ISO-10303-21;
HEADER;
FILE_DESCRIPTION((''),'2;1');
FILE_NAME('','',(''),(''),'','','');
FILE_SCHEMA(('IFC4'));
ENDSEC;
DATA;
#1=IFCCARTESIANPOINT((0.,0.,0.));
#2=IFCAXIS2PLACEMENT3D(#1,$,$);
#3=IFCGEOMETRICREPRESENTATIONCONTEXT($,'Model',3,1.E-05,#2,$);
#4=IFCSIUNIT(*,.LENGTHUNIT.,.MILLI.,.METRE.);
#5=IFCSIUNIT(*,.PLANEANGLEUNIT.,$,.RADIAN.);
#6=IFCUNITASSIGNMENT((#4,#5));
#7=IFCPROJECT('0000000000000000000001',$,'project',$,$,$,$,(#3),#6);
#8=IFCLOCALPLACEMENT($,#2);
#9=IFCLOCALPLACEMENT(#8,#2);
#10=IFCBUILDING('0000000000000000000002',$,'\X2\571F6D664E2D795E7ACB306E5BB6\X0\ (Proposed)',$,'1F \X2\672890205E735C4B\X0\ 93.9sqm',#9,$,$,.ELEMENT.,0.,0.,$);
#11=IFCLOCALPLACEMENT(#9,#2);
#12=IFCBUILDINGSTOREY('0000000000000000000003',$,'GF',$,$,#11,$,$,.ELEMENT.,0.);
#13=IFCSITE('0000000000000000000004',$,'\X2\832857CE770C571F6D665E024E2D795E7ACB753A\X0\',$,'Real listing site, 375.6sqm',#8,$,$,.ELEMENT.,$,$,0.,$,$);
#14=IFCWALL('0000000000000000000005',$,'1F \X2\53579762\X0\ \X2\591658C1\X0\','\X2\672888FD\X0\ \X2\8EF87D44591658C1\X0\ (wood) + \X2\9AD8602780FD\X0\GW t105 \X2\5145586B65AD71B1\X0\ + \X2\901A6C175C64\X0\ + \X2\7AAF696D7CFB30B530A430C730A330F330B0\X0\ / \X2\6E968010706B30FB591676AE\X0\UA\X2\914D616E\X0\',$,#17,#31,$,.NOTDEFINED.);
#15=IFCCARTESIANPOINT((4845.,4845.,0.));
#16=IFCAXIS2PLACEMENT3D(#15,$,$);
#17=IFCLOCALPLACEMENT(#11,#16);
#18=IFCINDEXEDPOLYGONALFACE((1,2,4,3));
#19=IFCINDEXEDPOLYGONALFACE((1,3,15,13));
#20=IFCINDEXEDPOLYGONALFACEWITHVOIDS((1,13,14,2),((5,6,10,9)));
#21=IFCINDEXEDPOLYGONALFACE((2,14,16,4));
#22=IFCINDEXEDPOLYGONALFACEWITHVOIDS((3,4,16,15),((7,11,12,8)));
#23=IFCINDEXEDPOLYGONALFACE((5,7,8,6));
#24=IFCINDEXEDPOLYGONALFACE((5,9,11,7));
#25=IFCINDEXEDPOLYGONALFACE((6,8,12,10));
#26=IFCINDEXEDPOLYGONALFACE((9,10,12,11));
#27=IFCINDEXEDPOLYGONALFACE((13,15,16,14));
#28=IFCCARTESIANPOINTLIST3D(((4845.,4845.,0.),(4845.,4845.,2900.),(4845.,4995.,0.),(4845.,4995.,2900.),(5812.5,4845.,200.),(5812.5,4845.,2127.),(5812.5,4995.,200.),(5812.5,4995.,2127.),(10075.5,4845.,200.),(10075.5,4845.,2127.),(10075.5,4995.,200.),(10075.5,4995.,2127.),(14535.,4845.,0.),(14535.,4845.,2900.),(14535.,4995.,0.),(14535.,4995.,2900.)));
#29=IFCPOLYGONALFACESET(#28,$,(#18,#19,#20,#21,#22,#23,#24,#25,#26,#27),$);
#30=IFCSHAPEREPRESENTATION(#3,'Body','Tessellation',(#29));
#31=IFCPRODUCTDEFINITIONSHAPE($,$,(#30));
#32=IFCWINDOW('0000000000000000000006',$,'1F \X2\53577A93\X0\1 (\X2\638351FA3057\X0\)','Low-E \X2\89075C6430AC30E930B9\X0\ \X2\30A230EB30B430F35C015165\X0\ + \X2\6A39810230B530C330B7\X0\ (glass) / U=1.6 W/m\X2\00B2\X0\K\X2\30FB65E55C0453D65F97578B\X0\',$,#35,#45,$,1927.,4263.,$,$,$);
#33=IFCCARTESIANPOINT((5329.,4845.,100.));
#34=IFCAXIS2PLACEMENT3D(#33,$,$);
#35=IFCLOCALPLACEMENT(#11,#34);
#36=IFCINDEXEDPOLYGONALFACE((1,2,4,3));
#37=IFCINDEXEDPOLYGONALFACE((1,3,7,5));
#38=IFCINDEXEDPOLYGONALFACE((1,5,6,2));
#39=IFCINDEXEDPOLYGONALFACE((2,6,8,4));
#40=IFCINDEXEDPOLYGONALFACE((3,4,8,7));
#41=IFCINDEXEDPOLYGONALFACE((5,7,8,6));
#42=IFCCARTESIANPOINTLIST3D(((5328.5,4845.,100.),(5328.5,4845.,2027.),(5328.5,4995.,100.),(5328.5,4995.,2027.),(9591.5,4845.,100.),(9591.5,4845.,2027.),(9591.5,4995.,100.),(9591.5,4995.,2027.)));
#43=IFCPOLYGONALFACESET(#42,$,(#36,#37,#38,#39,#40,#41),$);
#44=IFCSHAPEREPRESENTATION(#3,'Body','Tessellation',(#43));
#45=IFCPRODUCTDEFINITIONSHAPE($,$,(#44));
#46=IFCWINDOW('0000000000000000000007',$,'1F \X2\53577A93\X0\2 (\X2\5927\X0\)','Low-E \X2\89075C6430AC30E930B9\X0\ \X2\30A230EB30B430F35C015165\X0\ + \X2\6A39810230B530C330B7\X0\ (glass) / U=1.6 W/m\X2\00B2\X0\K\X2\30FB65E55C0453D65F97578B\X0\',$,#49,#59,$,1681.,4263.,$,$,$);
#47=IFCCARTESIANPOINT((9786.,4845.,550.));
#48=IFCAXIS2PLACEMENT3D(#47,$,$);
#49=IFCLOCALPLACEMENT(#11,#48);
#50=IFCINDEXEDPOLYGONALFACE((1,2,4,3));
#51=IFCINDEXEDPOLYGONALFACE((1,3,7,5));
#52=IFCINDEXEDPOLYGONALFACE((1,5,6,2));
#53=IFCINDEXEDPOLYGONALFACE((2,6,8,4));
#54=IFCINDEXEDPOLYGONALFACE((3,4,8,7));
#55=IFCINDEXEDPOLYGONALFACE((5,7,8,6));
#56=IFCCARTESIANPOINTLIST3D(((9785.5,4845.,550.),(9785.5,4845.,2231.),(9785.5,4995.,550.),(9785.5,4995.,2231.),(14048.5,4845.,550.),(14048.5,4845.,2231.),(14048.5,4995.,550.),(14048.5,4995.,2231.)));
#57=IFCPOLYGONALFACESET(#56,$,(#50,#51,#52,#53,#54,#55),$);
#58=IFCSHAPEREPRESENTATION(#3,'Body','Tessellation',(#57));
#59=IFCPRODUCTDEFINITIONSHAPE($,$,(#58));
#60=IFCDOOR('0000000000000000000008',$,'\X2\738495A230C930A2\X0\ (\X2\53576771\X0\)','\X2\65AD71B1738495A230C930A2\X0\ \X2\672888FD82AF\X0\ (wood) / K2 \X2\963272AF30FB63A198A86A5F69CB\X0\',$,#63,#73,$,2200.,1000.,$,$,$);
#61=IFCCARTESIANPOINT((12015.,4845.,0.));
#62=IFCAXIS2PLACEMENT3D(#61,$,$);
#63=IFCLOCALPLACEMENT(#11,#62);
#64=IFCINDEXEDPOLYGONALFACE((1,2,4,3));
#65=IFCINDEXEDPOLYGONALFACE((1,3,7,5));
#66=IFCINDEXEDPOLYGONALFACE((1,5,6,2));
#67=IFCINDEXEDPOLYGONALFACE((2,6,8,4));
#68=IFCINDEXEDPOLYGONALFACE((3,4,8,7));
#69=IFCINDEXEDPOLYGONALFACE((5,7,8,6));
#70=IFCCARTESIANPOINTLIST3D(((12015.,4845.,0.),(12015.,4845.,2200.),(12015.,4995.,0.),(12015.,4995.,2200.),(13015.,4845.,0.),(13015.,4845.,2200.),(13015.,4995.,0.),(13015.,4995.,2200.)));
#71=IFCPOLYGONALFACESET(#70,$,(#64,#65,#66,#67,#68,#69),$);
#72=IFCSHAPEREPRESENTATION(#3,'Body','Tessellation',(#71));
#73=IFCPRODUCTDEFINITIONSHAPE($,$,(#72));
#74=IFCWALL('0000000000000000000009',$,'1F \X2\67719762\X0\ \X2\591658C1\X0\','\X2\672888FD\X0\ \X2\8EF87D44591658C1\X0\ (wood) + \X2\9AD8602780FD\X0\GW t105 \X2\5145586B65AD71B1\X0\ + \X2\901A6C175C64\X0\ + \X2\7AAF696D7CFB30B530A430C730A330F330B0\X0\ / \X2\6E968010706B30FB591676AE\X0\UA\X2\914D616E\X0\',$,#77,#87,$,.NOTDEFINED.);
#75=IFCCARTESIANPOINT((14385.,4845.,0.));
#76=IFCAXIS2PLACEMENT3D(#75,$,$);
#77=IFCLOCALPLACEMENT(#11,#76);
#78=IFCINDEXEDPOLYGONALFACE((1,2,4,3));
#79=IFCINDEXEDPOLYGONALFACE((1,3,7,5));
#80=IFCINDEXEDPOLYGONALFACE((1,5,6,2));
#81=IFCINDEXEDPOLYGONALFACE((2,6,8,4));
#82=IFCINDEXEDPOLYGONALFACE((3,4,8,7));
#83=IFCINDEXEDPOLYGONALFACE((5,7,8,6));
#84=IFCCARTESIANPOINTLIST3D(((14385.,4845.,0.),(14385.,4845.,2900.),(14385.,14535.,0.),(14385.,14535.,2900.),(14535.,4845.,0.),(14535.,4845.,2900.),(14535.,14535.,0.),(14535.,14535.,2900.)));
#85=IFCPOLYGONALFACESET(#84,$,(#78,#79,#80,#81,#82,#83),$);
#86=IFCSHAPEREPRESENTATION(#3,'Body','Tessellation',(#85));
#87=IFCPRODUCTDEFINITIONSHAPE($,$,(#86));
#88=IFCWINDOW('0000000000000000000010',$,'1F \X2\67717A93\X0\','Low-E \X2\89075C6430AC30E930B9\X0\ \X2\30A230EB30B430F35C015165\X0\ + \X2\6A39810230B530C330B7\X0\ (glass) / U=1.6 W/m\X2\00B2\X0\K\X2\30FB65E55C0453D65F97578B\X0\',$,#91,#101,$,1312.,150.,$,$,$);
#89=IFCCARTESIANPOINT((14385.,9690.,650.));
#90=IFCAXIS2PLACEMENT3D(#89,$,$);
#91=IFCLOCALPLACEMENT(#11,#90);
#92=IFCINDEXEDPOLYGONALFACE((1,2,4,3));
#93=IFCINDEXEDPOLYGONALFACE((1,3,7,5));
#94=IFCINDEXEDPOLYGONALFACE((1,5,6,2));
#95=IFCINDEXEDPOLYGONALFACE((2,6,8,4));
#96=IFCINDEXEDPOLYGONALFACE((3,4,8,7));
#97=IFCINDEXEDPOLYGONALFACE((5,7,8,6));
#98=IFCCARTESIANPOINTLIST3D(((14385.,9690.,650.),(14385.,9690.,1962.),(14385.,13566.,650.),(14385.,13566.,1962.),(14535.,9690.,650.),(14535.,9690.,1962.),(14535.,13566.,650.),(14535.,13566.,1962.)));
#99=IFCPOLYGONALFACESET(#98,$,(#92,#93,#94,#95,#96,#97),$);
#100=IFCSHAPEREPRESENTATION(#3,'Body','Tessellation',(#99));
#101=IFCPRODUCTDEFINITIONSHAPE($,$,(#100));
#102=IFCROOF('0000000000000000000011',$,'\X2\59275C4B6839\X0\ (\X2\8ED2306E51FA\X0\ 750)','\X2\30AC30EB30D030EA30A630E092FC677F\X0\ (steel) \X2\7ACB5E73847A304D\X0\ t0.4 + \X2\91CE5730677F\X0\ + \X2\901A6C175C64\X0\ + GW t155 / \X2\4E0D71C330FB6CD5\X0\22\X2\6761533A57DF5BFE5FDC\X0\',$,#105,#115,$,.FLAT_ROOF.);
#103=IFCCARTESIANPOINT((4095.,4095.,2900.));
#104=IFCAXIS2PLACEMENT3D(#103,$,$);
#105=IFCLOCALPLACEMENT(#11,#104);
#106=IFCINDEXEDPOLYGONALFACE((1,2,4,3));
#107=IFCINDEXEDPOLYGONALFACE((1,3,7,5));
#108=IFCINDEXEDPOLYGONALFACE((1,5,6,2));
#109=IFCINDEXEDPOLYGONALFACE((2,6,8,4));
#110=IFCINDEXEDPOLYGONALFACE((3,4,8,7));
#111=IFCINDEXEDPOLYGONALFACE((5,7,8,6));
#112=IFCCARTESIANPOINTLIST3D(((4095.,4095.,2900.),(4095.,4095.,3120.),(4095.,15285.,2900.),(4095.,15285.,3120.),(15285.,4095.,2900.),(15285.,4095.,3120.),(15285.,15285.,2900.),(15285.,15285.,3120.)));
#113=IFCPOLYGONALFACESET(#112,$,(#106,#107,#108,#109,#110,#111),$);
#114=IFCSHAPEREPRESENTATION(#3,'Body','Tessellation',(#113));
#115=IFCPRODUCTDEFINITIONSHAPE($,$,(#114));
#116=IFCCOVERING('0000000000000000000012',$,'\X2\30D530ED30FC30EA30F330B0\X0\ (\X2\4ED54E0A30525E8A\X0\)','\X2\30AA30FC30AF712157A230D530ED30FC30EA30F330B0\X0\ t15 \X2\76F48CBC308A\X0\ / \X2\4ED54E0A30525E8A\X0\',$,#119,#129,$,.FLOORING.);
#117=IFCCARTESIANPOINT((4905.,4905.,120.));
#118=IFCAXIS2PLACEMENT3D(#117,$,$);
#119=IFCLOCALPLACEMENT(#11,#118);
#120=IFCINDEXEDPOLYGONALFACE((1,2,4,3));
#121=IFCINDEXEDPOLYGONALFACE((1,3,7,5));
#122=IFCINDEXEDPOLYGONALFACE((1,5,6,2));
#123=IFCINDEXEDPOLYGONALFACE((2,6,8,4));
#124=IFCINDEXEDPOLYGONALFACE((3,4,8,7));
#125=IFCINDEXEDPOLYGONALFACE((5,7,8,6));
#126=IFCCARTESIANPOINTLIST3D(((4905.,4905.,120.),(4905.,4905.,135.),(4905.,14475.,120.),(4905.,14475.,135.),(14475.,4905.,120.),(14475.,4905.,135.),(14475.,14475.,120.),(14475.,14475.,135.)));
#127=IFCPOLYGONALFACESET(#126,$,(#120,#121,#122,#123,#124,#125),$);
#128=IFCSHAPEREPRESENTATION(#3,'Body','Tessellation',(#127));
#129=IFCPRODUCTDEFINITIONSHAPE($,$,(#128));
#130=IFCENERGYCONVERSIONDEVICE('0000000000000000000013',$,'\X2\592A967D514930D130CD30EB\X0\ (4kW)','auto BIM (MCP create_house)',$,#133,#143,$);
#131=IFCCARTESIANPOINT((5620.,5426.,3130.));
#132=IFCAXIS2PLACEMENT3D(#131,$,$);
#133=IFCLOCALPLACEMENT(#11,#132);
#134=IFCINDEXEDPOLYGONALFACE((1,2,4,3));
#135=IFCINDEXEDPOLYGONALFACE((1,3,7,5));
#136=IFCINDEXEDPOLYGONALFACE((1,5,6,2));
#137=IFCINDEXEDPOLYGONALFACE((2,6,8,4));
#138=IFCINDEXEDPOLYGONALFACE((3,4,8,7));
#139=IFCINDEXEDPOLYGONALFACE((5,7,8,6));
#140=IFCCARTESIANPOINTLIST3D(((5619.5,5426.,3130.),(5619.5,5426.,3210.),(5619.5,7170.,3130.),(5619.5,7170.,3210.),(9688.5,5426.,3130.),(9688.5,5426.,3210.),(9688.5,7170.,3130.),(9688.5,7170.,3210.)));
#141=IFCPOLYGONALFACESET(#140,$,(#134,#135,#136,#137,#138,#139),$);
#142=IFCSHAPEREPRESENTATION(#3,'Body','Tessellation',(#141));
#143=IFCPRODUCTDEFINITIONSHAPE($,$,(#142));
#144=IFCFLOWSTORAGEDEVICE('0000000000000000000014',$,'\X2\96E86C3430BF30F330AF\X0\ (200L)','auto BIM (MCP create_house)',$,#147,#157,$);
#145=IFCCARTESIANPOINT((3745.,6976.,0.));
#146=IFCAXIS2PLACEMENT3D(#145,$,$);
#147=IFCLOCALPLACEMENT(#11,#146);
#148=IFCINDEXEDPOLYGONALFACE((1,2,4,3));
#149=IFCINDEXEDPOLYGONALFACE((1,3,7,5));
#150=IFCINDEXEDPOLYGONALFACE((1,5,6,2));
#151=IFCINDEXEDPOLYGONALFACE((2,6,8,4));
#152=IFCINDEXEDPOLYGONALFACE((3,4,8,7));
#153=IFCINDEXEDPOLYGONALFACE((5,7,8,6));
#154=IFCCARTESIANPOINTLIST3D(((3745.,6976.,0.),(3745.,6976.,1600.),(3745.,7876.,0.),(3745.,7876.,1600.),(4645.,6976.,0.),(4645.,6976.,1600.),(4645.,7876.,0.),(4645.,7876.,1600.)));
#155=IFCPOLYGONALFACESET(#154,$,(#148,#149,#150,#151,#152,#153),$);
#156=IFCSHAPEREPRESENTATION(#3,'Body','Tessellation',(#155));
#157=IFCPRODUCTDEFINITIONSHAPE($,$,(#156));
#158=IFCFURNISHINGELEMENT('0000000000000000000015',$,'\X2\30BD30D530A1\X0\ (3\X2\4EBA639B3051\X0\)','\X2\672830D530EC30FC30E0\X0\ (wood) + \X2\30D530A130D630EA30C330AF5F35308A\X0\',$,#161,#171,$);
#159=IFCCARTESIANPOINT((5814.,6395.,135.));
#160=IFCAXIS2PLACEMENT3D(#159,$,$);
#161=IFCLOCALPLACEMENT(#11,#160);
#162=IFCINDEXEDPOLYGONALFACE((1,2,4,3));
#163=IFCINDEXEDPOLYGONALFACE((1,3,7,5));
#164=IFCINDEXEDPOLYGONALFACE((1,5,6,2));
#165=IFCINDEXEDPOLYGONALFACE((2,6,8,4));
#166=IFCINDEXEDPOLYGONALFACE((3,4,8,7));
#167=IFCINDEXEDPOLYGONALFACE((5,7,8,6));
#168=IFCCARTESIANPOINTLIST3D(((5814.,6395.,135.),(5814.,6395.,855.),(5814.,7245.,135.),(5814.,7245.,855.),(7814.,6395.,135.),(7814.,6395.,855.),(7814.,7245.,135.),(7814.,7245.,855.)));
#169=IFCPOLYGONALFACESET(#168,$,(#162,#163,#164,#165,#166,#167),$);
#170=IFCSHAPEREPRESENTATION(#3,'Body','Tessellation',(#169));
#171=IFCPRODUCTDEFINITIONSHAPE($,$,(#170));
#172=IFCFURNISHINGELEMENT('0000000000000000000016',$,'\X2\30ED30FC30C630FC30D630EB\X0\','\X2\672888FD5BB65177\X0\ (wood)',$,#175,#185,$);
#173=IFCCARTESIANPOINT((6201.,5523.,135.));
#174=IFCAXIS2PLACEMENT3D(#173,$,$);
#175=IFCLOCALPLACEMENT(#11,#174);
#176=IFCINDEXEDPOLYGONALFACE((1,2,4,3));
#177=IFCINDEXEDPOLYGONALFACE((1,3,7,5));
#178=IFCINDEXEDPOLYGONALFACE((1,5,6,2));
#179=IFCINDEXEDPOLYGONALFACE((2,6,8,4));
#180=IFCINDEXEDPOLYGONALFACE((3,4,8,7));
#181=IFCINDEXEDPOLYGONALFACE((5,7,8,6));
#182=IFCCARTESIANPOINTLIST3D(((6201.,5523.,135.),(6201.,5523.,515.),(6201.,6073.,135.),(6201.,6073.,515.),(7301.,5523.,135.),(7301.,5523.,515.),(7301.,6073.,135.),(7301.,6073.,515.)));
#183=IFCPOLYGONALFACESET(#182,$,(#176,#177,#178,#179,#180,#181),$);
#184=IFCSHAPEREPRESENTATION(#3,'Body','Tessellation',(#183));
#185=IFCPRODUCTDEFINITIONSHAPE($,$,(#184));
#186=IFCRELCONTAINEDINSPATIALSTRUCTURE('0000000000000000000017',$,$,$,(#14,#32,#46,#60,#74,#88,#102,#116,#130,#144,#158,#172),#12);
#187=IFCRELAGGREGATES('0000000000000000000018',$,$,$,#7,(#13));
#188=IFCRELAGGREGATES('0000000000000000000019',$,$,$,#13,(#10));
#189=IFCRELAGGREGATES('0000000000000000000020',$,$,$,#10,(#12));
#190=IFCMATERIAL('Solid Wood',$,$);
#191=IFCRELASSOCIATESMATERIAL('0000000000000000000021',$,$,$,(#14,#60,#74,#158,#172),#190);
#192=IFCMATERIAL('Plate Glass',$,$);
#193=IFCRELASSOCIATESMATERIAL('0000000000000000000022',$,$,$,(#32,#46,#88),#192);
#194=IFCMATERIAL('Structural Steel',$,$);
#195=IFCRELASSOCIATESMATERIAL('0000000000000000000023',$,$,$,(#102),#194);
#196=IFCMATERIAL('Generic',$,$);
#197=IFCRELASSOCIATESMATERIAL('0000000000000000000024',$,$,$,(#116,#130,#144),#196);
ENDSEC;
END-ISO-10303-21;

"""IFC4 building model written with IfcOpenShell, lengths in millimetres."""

from ifc_helpers import new_model, si_unit, frame, frame_2d, origin, place, context, project, spatial, rectangle, extrude, material, element, fill, save


model = new_model("IFC4")

# Units and contexts
model_context = context("Model", 3, precision=1e-05, world=origin())
ifc_project = project(units=[si_unit("LENGTHUNIT", "METRE", prefix="MILLI"), si_unit("PLANEANGLEUNIT", "RADIAN")], contexts=[model_context])

# Site, building, storey
site_placement = place(None, origin())
site = spatial("IfcSite", under=ifc_project, at=site_placement, Name="茨城県土浦市中神立町", ObjectType="Real listing site, 375.6sqm", CompositionType="ELEMENT", RefElevation=0.0)
building_placement = place(site_placement, origin())
building = spatial("IfcBuilding", under=site, at=building_placement, Name="土浦中神立の家 (Proposed)", ObjectType="1F 木造平屋 93.9sqm", CompositionType="ELEMENT", ElevationOfRefHeight=0.0, ElevationOfTerrain=0.0)
storey_placement = place(building_placement, origin())
storey = spatial("IfcBuildingStorey", under=building, at=storey_placement, Name="GF", CompositionType="ELEMENT", Elevation=0.0)

# Shared definitions
ifc_material_1 = material(Name="Solid Wood")

# Wall, openings, windows, door
wall_1_placement = place(storey_placement, frame((4845.0, 4845.0, 0.0)))
wall_1 = element("IfcWall", 1, at=wall_1_placement, inside=storey, material=ifc_material_1, Name="1F 南面 外壁", Description="木製 軸組外壁 (wood) + 高性能GW t105 充填断熱 + 通気層 + 窯業系サイディング / 準耐火・外皮UA配慮", PredefinedType="NOTDEFINED", context=model_context, shape_type="SweptSolid", body=[
    extrude(rectangle(XDim=9690.0, YDim=150.0, at=frame_2d((4845.0, 75.0))), frame((4845.0, 4845.0, 0.0)), (0.0, 0.0, 1.0), 2900.0),
])
opening_1_placement = place(storey_placement, frame((5329.0, 4845.0, 100.0)))
opening_1 = element("IfcOpeningElement", 2, at=opening_1_placement, cuts=wall_1, PredefinedType="NOTDEFINED", context=model_context, shape_type="SweptSolid", body=[
    extrude(rectangle(XDim=4263.0, YDim=150.0, at=frame_2d((2131.0, 75.0))), frame((5329.0, 4845.0, 100.0)), (0.0, 0.0, 1.0), 1927.0),
])
opening_2_placement = place(storey_placement, frame((9786.0, 4845.0, 550.0)))
opening_2 = element("IfcOpeningElement", 3, at=opening_2_placement, cuts=wall_1, PredefinedType="NOTDEFINED", context=model_context, shape_type="SweptSolid", body=[
    extrude(rectangle(XDim=4263.0, YDim=150.0, at=frame_2d((2131.0, 75.0))), frame((9786.0, 4845.0, 550.0)), (0.0, 0.0, 1.0), 1681.0),
])
opening_3_placement = place(storey_placement, frame((12015.0, 4845.0, 0.0)))
opening_3 = element("IfcOpeningElement", 4, at=opening_3_placement, cuts=wall_1, PredefinedType="NOTDEFINED", context=model_context, shape_type="SweptSolid", body=[
    extrude(rectangle(XDim=1000.0, YDim=150.0, at=frame_2d((500.0, 75.0))), frame((12015.0, 4845.0, 0.0)), (0.0, 0.0, 1.0), 2200.0),
])
ifc_material_2 = material(Name="Plate Glass")
window_1_placement = place(storey_placement, frame((5329.0, 4845.0, 100.0)))
window_1 = element("IfcWindow", 5, at=window_1_placement, inside=storey, material=ifc_material_2, Name="1F 南窓1 (掃出し)", Description="Low-E 複層ガラス アルゴン封入 + 樹脂サッシ (glass) / U=1.6 W/m²K・日射取得型", OverallHeight=1927.0, OverallWidth=4263.0, context=model_context, shape_type="SweptSolid", body=[
    extrude(rectangle(XDim=4263.0, YDim=150.0, at=frame_2d((2131.0, 75.0))), frame((5329.0, 4845.0, 100.0)), (0.0, 0.0, 1.0), 1927.0),
])
fill(opening_1, window_1)
window_2_placement = place(storey_placement, frame((9786.0, 4845.0, 550.0)))
window_2 = element("IfcWindow", 6, at=window_2_placement, inside=storey, material=ifc_material_2, Name="1F 南窓2 (大)", Description="Low-E 複層ガラス アルゴン封入 + 樹脂サッシ (glass) / U=1.6 W/m²K・日射取得型", OverallHeight=1681.0, OverallWidth=4263.0, context=model_context, shape_type="SweptSolid", body=[
    extrude(rectangle(XDim=4263.0, YDim=150.0, at=frame_2d((2131.0, 75.0))), frame((9786.0, 4845.0, 550.0)), (0.0, 0.0, 1.0), 1681.0),
])
fill(opening_2, window_2)
door_placement = place(storey_placement, frame((12015.0, 4845.0, 0.0)))
door = element("IfcDoor", 7, at=door_placement, inside=storey, material=ifc_material_1, Name="玄関ドア (南東)", Description="断熱玄関ドア 木製芯 (wood) / K2 防犯・採風機構", OverallHeight=2200.0, OverallWidth=1000.0, context=model_context, shape_type="SweptSolid", body=[
    extrude(rectangle(XDim=1000.0, YDim=150.0, at=frame_2d((500.0, 75.0))), frame((12015.0, 4845.0, 0.0)), (0.0, 0.0, 1.0), 2200.0),
])
fill(opening_3, door)

# Wall, opening, window
wall_2_placement = place(storey_placement, frame((14385.0, 4845.0, 0.0)))
wall_2 = element("IfcWall", 8, at=wall_2_placement, inside=storey, material=ifc_material_1, Name="1F 東面 外壁", Description="木製 軸組外壁 (wood) + 高性能GW t105 充填断熱 + 通気層 + 窯業系サイディング / 準耐火・外皮UA配慮", PredefinedType="NOTDEFINED", context=model_context, shape_type="SweptSolid", body=[
    extrude(rectangle(XDim=150.0, YDim=9690.0, at=frame_2d((75.0, 4845.0))), frame((14385.0, 4845.0, 0.0)), (0.0, 0.0, 1.0), 2900.0),
])
opening_4_placement = place(storey_placement, frame((14385.0, 9690.0, 650.0)))
opening_4 = element("IfcOpeningElement", 9, at=opening_4_placement, cuts=wall_2, PredefinedType="NOTDEFINED", context=model_context, shape_type="SweptSolid", body=[
    extrude(rectangle(XDim=150.0, YDim=3876.0, at=frame_2d((75.0, 1938.0))), frame((14385.0, 9690.0, 650.0)), (0.0, 0.0, 1.0), 1312.0),
])
window_3_placement = place(storey_placement, frame((14385.0, 9690.0, 650.0)))
window_3 = element("IfcWindow", 10, at=window_3_placement, inside=storey, material=ifc_material_2, Name="1F 東窓", Description="Low-E 複層ガラス アルゴン封入 + 樹脂サッシ (glass) / U=1.6 W/m²K・日射取得型", OverallHeight=1312.0, OverallWidth=150.0, context=model_context, shape_type="SweptSolid", body=[
    extrude(rectangle(XDim=150.0, YDim=3876.0, at=frame_2d((75.0, 1938.0))), frame((14385.0, 9690.0, 650.0)), (0.0, 0.0, 1.0), 1312.0),
])
fill(opening_4, window_3)

# Roof
ifc_material_3 = material(Name="Structural Steel")
roof_placement = place(storey_placement, frame((4095.0, 4095.0, 2900.0)))
element("IfcRoof", 11, at=roof_placement, inside=storey, material=ifc_material_3, Name="大屋根 (軒の出 750)", Description="ガルバリウム鋼板 (steel) 立平葺き t0.4 + 野地板 + 通気層 + GW t155 / 不燃・法22条区域対応", PredefinedType="FLAT_ROOF", context=model_context, shape_type="SweptSolid", body=[
    extrude(rectangle(XDim=11190.0, YDim=11190.0, at=frame_2d((5595.0, 5595.0))), frame((4095.0, 4095.0, 2900.0)), (0.0, 0.0, 1.0), 220.0),
])

# Covering
ifc_material_4 = material(Name="Generic")
covering_placement = place(storey_placement, frame((4905.0, 4905.0, 120.0)))
element("IfcCovering", 12, at=covering_placement, inside=storey, material=ifc_material_4, Name="フローリング (仕上げ床)", Description="オーク無垢フローリング t15 直貼り / 仕上げ床", PredefinedType="FLOORING", context=model_context, shape_type="SweptSolid", body=[
    extrude(rectangle(XDim=9570.0, YDim=9570.0, at=frame_2d((4785.0, 4785.0))), frame((4905.0, 4905.0, 120.0)), (0.0, 0.0, 1.0), 15.0),
])

# Energy conversion device
energy_conversion_device_placement = place(storey_placement, frame((5620.0, 5426.0, 3130.0)))
element("IfcEnergyConversionDevice", 13, at=energy_conversion_device_placement, inside=storey, material=ifc_material_4, Name="太陽光パネル (4kW)", Description="auto BIM (MCP create_house)", context=model_context, shape_type="SweptSolid", body=[
    extrude(rectangle(XDim=4069.0, YDim=1744.0, at=frame_2d((2034.0, 872.0))), frame((5620.0, 5426.0, 3130.0)), (0.0, 0.0, 1.0), 80.0),
])

# Flow storage device
flow_storage_device_placement = place(storey_placement, frame((3745.0, 6976.0, 0.0)))
element("IfcFlowStorageDevice", 14, at=flow_storage_device_placement, inside=storey, material=ifc_material_4, Name="雨水タンク (200L)", Description="auto BIM (MCP create_house)", context=model_context, shape_type="SweptSolid", body=[
    extrude(rectangle(XDim=900.0, YDim=900.0, at=frame_2d((450.0, 450.0))), frame((3745.0, 6976.0, 0.0)), (0.0, 0.0, 1.0), 1600.0),
])

# Furnishing elements
furnishing_1_placement = place(storey_placement, frame((5814.0, 6395.0, 135.0)))
element("IfcFurnishingElement", 15, at=furnishing_1_placement, inside=storey, material=ifc_material_1, Name="ソファ (3人掛け)", Description="木フレーム (wood) + ファブリック張り", context=model_context, shape_type="SweptSolid", body=[
    extrude(rectangle(XDim=2000.0, YDim=850.0, at=frame_2d((1000.0, 425.0))), frame((5814.0, 6395.0, 135.0)), (0.0, 0.0, 1.0), 720.0),
])
furnishing_2_placement = place(storey_placement, frame((6201.0, 5523.0, 135.0)))
element("IfcFurnishingElement", 16, at=furnishing_2_placement, inside=storey, material=ifc_material_1, Name="ローテーブル", Description="木製家具 (wood)", context=model_context, shape_type="SweptSolid", body=[
    extrude(rectangle(XDim=1100.0, YDim=550.0, at=frame_2d((550.0, 275.0))), frame((6201.0, 5523.0, 135.0)), (0.0, 0.0, 1.0), 380.0),
])

save(model, "model.ifc")
